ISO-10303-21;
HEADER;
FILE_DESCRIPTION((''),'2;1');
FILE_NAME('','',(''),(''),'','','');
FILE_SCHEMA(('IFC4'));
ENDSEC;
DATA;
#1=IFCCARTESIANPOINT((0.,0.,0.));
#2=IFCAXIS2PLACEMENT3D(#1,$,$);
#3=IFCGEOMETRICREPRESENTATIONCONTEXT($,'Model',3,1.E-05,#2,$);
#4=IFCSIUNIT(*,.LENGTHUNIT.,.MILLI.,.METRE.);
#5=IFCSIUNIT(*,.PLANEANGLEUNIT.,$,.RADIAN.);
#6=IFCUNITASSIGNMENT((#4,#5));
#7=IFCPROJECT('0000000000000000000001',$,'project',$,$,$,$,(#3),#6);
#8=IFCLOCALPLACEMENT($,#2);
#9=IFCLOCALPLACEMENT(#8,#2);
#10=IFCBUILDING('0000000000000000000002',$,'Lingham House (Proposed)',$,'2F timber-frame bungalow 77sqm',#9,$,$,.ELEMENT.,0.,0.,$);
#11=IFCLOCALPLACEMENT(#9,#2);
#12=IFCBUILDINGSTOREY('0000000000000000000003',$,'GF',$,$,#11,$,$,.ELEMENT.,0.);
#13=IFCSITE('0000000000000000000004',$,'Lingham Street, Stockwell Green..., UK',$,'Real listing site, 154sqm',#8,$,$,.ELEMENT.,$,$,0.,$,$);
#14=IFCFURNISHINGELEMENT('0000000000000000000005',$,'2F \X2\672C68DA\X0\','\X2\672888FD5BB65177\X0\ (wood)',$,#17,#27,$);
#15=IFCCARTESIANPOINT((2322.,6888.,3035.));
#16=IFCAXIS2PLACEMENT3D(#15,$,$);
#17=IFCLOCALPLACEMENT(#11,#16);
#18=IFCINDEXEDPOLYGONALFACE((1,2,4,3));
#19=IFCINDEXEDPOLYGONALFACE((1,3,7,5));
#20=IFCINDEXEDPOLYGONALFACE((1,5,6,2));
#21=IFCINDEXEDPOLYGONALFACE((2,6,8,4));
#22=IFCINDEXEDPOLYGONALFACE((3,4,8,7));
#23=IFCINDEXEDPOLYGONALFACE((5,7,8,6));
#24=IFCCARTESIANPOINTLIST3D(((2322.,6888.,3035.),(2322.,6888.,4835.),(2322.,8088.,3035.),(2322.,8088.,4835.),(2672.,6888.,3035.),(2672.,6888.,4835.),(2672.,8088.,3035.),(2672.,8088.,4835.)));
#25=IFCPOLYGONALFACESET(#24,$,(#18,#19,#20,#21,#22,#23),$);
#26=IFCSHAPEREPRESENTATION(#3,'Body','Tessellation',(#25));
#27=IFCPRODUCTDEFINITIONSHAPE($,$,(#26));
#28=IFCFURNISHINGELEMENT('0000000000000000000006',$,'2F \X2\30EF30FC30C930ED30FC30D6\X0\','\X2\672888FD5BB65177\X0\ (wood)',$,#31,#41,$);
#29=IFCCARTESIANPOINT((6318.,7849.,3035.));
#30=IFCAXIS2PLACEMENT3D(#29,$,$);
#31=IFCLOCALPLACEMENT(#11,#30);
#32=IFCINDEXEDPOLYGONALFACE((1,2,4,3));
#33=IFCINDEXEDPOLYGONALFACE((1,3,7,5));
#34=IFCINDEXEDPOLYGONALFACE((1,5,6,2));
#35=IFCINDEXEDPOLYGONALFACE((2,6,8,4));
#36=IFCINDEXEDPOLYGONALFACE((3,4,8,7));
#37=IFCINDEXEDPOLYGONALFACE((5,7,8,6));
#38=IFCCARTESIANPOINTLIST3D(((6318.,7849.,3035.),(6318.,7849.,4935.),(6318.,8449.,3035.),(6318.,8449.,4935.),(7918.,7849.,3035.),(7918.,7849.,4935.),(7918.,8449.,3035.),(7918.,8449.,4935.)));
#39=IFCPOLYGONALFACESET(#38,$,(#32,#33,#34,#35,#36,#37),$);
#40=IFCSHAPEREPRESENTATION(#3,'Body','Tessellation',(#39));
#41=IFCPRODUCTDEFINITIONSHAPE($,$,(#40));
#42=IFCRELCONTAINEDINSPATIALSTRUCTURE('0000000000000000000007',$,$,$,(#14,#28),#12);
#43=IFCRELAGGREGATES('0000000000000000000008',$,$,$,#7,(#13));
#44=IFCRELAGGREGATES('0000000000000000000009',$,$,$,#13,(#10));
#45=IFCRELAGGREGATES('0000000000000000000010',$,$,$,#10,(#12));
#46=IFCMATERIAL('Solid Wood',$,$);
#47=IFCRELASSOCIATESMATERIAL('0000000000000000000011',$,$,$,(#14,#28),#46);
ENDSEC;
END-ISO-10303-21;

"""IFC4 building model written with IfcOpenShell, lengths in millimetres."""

from ifc_helpers import new_model, si_unit, frame, frame_2d, origin, place, context, project, spatial, rectangle, extrude, material, element, save


model = new_model("IFC4")

# Units and contexts
model_context = context("Model", 3, precision=1e-05, world=origin())
ifc_project = project(units=[si_unit("LENGTHUNIT", "METRE", prefix="MILLI"), si_unit("PLANEANGLEUNIT", "RADIAN")], contexts=[model_context])

# Site, building, storey
site_placement = place(None, origin())
site = spatial("IfcSite", under=ifc_project, at=site_placement, Name="Lingham Street, Stockwell Green..., UK", ObjectType="Real listing site, 154sqm", CompositionType="ELEMENT", RefElevation=0.0)
building_placement = place(site_placement, origin())
building = spatial("IfcBuilding", under=site, at=building_placement, Name="Lingham House (Proposed)", ObjectType="2F timber-frame bungalow 77sqm", CompositionType="ELEMENT", ElevationOfRefHeight=0.0, ElevationOfTerrain=0.0)
storey_placement = place(building_placement, origin())
storey = spatial("IfcBuildingStorey", under=building, at=storey_placement, Name="GF", CompositionType="ELEMENT", Elevation=0.0)

# Shared definitions
ifc_material_1 = material(Name="Solid Wood")

# Furnishing elements
furnishing_1_placement = place(storey_placement, frame((2322.0, 6888.0, 3035.0)))
element("IfcFurnishingElement", 1, at=furnishing_1_placement, inside=storey, material=ifc_material_1, Name="2F 本棚", Description="木製家具 (wood)", context=model_context, shape_type="SweptSolid", body=[
    extrude(rectangle(XDim=350.0, YDim=1200.0, at=frame_2d((175.0, 600.0))), frame((2322.0, 6888.0, 3035.0)), (0.0, 0.0, 1.0), 1800.0),
])
furnishing_2_placement = place(storey_placement, frame((6318.0, 7849.0, 3035.0)))
element("IfcFurnishingElement", 2, at=furnishing_2_placement, inside=storey, material=ifc_material_1, Name="2F ワードローブ", Description="木製家具 (wood)", context=model_context, shape_type="SweptSolid", body=[
    extrude(rectangle(XDim=1600.0, YDim=600.0, at=frame_2d((800.0, 300.0))), frame((6318.0, 7849.0, 3035.0)), (0.0, 0.0, 1.0), 1900.0),
])

save(model, "model.ifc")
